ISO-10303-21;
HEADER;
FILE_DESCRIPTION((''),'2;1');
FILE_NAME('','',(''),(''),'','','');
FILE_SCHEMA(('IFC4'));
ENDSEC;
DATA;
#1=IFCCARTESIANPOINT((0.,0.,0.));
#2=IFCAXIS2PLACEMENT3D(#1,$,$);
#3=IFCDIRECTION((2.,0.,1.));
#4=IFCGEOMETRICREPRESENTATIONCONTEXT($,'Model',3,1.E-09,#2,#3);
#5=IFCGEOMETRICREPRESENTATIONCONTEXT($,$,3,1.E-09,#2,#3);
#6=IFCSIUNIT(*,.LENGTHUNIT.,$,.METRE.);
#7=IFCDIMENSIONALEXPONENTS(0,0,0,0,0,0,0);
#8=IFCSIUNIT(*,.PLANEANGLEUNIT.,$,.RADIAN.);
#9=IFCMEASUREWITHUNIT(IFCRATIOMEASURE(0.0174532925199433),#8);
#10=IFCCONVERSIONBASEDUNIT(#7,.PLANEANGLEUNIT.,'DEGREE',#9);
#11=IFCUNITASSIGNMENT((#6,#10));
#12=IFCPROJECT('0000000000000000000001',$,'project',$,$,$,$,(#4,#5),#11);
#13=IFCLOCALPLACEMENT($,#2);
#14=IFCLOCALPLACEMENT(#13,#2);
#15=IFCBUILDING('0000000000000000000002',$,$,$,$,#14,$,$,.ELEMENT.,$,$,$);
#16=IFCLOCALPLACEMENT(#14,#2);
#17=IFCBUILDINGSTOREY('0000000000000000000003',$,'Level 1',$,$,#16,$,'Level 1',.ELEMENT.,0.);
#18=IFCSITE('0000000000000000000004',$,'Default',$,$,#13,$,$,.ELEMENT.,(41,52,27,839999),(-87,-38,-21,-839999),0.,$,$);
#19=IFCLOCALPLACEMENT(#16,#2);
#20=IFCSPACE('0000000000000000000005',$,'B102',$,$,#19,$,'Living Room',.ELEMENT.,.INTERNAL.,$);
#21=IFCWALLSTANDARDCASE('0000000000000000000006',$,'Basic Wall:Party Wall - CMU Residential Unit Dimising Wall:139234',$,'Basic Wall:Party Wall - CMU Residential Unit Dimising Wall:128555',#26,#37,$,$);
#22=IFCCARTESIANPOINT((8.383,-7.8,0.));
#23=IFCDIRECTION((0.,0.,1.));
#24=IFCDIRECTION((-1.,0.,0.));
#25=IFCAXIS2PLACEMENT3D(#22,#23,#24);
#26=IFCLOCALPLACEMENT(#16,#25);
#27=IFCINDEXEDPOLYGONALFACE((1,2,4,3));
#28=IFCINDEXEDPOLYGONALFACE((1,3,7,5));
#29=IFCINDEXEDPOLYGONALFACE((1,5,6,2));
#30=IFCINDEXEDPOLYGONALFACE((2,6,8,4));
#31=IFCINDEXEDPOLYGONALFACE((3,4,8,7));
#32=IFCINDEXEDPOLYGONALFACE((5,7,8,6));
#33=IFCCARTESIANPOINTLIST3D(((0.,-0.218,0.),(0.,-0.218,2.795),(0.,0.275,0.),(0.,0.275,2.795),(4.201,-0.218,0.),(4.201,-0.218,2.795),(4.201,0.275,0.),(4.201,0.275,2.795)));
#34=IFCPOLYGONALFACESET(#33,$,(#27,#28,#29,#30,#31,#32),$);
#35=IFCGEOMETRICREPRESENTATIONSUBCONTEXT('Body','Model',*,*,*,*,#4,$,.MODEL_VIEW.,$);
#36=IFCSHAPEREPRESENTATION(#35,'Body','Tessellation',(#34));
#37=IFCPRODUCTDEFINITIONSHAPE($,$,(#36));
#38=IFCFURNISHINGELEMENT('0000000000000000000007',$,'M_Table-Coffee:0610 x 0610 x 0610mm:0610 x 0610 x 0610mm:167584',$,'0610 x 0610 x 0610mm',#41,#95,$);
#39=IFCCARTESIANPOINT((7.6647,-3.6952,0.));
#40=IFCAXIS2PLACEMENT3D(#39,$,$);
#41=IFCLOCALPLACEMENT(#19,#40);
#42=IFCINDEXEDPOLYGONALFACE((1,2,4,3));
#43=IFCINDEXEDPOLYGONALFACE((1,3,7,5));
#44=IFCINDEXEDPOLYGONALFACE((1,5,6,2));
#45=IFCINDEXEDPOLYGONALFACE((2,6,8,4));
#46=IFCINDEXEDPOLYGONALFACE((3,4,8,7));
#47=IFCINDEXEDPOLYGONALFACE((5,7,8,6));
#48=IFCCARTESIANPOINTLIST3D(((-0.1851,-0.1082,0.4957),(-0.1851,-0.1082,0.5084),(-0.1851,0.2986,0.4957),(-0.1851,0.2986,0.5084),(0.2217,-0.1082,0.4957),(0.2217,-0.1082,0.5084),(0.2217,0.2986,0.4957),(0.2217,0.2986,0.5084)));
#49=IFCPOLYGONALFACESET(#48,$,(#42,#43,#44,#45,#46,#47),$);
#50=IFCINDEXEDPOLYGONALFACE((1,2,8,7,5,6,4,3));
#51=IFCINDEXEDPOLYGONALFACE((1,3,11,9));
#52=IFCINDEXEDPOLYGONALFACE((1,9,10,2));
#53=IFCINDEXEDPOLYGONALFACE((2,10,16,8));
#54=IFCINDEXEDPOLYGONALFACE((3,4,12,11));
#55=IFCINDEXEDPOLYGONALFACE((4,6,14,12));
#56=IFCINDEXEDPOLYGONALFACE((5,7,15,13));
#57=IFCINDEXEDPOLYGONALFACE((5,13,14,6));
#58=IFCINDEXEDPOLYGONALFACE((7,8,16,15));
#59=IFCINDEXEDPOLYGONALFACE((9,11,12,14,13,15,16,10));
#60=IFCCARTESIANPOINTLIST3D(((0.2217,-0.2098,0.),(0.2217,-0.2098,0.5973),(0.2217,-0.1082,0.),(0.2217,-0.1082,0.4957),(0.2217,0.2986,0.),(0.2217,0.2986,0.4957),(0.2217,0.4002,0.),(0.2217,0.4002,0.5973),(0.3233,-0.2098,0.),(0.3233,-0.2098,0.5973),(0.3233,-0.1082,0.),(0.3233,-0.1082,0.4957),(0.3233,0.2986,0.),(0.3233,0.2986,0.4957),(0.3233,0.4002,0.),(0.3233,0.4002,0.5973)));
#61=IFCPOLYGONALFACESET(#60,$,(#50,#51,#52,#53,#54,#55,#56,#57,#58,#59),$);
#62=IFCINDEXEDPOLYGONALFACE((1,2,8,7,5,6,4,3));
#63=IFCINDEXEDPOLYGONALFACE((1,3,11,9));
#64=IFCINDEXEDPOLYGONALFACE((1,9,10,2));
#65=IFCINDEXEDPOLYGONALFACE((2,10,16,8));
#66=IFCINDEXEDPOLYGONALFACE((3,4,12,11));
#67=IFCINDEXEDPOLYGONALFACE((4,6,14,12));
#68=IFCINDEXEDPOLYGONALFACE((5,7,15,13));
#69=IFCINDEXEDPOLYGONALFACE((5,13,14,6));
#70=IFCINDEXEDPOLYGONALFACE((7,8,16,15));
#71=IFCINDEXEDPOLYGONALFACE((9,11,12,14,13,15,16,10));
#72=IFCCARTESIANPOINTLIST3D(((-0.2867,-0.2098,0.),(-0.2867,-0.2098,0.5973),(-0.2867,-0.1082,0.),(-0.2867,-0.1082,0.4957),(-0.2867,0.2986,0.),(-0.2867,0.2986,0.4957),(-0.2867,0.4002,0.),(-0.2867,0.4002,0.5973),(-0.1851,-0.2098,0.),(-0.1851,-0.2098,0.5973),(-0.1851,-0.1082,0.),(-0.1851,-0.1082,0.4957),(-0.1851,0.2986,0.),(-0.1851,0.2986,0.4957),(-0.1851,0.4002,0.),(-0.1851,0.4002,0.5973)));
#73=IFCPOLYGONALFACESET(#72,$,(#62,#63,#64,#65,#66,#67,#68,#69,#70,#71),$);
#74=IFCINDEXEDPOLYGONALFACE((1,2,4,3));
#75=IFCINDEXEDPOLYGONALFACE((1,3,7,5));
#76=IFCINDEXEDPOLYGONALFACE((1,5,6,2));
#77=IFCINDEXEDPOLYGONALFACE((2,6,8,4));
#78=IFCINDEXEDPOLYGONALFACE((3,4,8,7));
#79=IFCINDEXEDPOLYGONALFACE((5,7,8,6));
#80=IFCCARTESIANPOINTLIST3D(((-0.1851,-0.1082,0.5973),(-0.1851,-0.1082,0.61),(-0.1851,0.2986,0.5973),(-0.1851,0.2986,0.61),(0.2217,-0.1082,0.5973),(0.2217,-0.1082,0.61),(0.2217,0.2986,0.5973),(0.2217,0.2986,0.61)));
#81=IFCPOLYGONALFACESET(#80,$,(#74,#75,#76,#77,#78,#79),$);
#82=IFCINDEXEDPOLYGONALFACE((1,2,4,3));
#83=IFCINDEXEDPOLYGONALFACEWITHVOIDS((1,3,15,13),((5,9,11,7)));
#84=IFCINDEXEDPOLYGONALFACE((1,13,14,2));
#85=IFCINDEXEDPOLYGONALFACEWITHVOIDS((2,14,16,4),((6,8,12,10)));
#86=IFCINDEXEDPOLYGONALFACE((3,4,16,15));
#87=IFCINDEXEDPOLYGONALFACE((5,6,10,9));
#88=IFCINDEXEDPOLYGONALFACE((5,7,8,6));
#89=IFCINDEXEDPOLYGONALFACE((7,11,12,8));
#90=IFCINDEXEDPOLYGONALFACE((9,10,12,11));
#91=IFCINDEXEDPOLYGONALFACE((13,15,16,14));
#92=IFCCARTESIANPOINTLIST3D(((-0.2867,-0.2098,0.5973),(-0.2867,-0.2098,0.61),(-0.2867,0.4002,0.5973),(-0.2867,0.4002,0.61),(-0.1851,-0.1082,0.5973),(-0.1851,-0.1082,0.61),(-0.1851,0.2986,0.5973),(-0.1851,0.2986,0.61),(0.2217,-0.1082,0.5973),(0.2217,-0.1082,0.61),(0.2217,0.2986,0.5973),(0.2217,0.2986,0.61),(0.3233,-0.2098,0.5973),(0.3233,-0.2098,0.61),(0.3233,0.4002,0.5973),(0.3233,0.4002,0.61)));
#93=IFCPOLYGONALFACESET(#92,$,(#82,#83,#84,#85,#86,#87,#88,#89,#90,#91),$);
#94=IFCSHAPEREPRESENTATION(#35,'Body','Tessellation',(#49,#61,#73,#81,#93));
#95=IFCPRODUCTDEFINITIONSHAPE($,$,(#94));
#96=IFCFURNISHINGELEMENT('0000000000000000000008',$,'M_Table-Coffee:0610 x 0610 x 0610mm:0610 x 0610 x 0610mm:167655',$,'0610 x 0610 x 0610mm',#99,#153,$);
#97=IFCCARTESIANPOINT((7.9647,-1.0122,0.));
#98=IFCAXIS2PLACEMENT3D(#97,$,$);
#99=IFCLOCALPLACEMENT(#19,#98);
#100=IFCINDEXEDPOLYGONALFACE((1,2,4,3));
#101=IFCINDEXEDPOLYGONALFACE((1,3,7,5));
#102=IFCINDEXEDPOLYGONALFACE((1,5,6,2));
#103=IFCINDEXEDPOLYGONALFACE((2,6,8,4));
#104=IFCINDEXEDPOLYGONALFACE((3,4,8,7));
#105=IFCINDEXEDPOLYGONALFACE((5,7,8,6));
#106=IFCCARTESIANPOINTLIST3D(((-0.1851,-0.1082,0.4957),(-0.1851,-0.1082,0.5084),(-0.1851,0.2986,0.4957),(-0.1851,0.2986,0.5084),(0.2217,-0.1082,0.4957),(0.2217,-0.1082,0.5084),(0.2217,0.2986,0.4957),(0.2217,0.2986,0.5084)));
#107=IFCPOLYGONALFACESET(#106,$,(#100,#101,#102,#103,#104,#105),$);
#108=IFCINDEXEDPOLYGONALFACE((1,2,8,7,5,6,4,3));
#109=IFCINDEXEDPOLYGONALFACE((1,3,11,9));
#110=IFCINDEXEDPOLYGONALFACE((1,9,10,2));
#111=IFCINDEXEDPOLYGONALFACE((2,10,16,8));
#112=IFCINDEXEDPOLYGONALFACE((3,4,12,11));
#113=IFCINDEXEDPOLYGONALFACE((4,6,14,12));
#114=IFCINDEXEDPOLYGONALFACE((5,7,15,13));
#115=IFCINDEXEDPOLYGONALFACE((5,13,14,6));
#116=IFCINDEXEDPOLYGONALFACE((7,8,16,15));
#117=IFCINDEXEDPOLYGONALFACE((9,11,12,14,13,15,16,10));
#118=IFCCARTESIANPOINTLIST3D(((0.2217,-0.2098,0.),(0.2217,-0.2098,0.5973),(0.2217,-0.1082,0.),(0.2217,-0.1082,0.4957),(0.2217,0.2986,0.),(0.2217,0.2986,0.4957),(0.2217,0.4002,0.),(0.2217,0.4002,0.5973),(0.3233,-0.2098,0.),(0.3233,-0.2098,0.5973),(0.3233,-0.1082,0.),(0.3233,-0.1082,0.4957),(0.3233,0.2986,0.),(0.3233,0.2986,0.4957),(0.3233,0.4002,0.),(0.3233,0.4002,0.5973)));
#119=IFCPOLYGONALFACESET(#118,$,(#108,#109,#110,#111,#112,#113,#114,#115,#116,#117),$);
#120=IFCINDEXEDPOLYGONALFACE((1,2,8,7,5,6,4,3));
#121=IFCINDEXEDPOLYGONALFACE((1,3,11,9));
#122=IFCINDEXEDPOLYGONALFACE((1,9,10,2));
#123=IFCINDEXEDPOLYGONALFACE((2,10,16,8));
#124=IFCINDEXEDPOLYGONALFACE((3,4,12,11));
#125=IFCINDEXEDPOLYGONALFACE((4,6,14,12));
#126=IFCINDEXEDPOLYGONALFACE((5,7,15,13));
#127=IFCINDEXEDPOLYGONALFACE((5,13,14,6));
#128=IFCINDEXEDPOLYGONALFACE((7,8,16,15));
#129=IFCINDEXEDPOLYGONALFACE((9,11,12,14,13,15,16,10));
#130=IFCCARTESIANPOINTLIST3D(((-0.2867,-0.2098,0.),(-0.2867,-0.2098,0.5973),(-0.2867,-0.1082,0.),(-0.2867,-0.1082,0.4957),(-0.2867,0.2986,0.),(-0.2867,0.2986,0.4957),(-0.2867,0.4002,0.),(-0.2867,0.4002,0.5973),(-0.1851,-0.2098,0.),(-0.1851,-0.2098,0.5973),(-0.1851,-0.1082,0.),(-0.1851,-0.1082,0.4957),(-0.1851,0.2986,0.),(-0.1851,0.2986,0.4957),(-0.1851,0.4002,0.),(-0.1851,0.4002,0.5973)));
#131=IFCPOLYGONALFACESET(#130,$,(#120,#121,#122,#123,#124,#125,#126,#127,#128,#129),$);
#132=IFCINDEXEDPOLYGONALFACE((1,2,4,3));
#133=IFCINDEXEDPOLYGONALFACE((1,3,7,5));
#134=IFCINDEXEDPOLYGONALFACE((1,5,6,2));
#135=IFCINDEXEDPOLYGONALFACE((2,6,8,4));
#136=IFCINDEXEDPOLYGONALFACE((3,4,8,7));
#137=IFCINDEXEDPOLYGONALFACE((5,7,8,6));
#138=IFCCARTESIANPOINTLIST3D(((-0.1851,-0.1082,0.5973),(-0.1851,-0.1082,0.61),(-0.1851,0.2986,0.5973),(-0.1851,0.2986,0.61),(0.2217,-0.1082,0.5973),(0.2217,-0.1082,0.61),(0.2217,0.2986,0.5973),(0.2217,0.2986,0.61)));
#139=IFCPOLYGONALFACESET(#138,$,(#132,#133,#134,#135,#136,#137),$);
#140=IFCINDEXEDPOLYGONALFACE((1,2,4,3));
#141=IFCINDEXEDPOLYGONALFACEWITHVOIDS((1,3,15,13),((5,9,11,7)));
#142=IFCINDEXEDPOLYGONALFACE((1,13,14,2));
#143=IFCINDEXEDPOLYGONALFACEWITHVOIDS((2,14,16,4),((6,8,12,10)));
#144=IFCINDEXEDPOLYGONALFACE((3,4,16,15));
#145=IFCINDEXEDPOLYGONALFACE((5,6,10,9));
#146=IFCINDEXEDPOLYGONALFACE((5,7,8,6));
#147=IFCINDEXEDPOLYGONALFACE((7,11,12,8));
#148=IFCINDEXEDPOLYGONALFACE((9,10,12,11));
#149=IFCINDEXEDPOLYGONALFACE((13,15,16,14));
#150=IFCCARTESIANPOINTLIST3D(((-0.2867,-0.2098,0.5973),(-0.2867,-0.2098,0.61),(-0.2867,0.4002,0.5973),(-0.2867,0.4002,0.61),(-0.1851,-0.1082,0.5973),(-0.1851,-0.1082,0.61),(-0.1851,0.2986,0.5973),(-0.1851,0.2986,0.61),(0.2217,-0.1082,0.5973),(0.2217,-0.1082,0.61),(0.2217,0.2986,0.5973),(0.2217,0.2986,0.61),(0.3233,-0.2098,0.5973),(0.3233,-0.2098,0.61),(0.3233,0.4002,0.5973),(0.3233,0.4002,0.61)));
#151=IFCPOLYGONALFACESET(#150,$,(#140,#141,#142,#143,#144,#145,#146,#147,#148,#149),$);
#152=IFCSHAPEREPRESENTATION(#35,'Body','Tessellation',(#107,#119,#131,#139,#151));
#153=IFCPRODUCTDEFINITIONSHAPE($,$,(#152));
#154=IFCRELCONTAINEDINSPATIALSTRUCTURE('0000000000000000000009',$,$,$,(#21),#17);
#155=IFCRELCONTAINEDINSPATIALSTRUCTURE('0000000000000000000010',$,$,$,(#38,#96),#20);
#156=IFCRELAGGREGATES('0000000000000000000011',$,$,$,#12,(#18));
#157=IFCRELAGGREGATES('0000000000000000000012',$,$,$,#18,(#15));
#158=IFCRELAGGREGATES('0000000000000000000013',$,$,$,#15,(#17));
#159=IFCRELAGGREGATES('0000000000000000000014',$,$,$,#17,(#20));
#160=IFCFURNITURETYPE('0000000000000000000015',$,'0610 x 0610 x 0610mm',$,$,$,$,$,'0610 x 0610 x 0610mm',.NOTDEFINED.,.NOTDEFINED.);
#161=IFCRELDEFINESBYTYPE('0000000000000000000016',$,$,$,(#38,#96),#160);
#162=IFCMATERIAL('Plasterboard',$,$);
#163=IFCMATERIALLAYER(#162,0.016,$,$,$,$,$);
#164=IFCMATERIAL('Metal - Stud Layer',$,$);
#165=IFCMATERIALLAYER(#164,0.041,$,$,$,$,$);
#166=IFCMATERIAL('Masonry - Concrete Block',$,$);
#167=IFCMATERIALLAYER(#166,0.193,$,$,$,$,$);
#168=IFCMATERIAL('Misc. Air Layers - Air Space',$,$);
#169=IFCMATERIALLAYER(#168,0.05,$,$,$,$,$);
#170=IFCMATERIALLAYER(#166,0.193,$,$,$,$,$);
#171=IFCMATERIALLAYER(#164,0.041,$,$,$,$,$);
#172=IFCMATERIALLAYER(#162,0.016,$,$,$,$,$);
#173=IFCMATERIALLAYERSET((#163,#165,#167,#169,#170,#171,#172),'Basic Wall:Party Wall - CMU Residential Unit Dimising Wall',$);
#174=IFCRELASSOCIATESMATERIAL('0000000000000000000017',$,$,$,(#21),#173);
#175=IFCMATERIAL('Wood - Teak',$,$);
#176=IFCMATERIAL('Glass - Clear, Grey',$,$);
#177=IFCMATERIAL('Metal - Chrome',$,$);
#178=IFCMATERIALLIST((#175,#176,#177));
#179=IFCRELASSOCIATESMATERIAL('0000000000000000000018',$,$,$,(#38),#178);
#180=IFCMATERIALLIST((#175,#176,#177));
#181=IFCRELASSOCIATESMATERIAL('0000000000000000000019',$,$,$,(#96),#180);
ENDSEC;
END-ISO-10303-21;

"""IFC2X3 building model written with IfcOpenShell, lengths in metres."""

from ifc_helpers import new_model, entity, si_unit, converted_unit, direction, frame, frame_2d, origin, origin_2d_with_axis, place, context, subcontext, project, spatial, polyline, rectangle, outline, extrude, clip, bounded_halfspace, source, transform, mapped, material, material_list, layer, layer_set, layer_usage, type_object, type_shapes, element, save


model = new_model("IFC2X3")

# Units and contexts
model_context = context("Model", 3, precision=1e-09, world=origin(), true_north=direction((2.0, 0.0, 1.0)))
context_of_model = context(None, 3, precision=1e-09, world=origin(), true_north=direction((2.0, 0.0, 1.0)))
body_context = subcontext(model_context, "Body", "Model", "MODEL_VIEW")
ifc_project = project(units=[si_unit("LENGTHUNIT", "METRE"), converted_unit("PLANEANGLEUNIT", "DEGREE", entity("IfcRatioMeasure", 0.0174532925199433), si_unit("PLANEANGLEUNIT", "RADIAN"), dimensions=[0, 0, 0, 0, 0, 0, 0])], contexts=[model_context, context_of_model])

# Site, building, storey
site_placement = place(None, origin())
site = spatial("IfcSite", under=ifc_project, at=site_placement, Name="Default", CompositionType="ELEMENT", RefLatitude=(41, 52, 27, 839999), RefLongitude=(-87, -38, -21, -839999), RefElevation=0.0)
building_placement = place(site_placement, origin())
building = spatial("IfcBuilding", under=site, at=building_placement, CompositionType="ELEMENT")
storey_placement = place(building_placement, origin())
storey = spatial("IfcBuildingStorey", under=building, at=storey_placement, Name="Level 1", LongName="Level 1", CompositionType="ELEMENT", Elevation=0.0)

# Shared definitions
ifc_material_1 = material(Name="Misc. Air Layers - Air Space")
ifc_material_2 = material(Name="Masonry - Concrete Block")
ifc_material_3 = material(Name="Metal - Stud Layer")
ifc_material_4 = material(Name="Plasterboard")

# Wall
ifc_layer_1 = layer(ifc_material_4, 0.016)
ifc_layer_2 = layer(ifc_material_3, 0.041)
ifc_layer_3 = layer(ifc_material_2, 0.193)
ifc_layer_4 = layer(ifc_material_1, 0.05)
ifc_layer_5 = layer(ifc_material_2, 0.193)
ifc_layer_6 = layer(ifc_material_3, 0.041)
ifc_layer_7 = layer(ifc_material_4, 0.016)
ifc_layer_set_1 = layer_set([ifc_layer_1, ifc_layer_2, ifc_layer_3, ifc_layer_4, ifc_layer_5, ifc_layer_6, ifc_layer_7], Name="Basic Wall:Party Wall - CMU Residential Unit Dimising Wall")
ifc_layer_usage_1 = layer_usage(ifc_layer_set_1, "AXIS2", "NEGATIVE", 0.275)
wall_1_placement = place(storey_placement, frame((8.383, -7.8, 0.0), z_axis=(0.0, 0.0, 1.0), x_axis=(-1.0, 0.0, 0.0)))
element("IfcWallStandardCase", 1, at=wall_1_placement, inside=storey, material=ifc_layer_usage_1, Name="Basic Wall:Party Wall - CMU Residential Unit Dimising Wall:139234", ObjectType="Basic Wall:Party Wall - CMU Residential Unit Dimising Wall:128555", context=body_context, shape_type="Clipping", body=[
    clip(clip(extrude(rectangle(XDim=4.201, YDim=0.55, at=frame_2d((2.1005, 0.0), x_axis=(-1.0, 0.0))), origin(), (0.0, 0.0, 1.0), 2.795), bounded_halfspace(frame((0.0, -0.218, 2.795), z_axis=(0.0, 1.0, 0.0), x_axis=(-1.0, 0.0, 0.0)), True, frame((0.0, -0.218, 2.795), z_axis=(0.0, 1.0, 0.0), x_axis=(-1.0, 0.0, 0.0)), polyline([(0.0, 0.0), (-3.708, 0.0), (-4.201, 0.0), (-4.201, -2.795), (0.0, -2.795), (0.0, 0.0)]))), bounded_halfspace(frame((4.201, 0.275, 0.0), z_axis=(-1.0, 0.0, 0.0), x_axis=(0.0, -1.0, 0.0)), True, frame((4.201, 0.275, 0.0), z_axis=(-1.0, 0.0, 0.0), x_axis=(0.0, -1.0, 0.0)), polyline([(0.0, 0.0), (0.493, 0.0), (0.493, 2.795), (0.0, 2.795), (0.0, 0.0)]))),
])

# Shared definitions
space_1_placement = place(storey_placement, origin())
space_1 = spatial("IfcSpace", under=storey, at=space_1_placement, Name="B102", LongName="Living Room", CompositionType="ELEMENT", InteriorOrExteriorSpace="INTERNAL")

# Furnishing elements
ifc_material_5 = material(Name="Wood - Teak")
ifc_material_6 = material(Name="Glass - Clear, Grey")
ifc_material_7 = material(Name="Metal - Chrome")
ifc_material_list_1 = material_list([ifc_material_5, ifc_material_6, ifc_material_7])
furniture_type_1 = type_object("IfcFurnitureType", Name="0610 x 0610 x 0610mm", ElementType="0610 x 0610 x 0610mm", AssemblyPlace="NOTDEFINED")
shared_shape_1 = source(origin(), body_context, "Body", "SweptSolid", [
    extrude(rectangle(XDim=0.4068, YDim=0.4068, at=origin_2d_with_axis()), frame((0.0183, 0.0952, 0.4957), z_axis=(0.0, 0.0, 1.0), x_axis=(-1.0, 0.0, 0.0)), (0.0, 0.0, 1.0), 0.0127),
    extrude(outline(polyline([(-0.2732, -0.305), (0.324, -0.305), (0.324, 0.305), (-0.2732, 0.305), (-0.2732, 0.2034), (0.2225, 0.2034), (0.2225, -0.2034), (-0.2732, -0.2034), (-0.2732, -0.305)])), frame((0.2217, 0.0952, 0.2732), z_axis=(1.0, 0.0, 0.0), x_axis=(0.0, 0.0, 1.0)), (0.0, 0.0, 1.0), 0.1016),
    extrude(outline(polyline([(-0.305, -0.3241), (0.305, -0.3241), (0.305, 0.2733), (0.2034, 0.2733), (0.2034, -0.2224), (-0.2034, -0.2224), (-0.2034, 0.2733), (-0.305, 0.2733), (-0.305, -0.3241)])), frame((-0.2867, 0.0952, 0.2733), z_axis=(1.0, 0.0, 0.0), x_axis=(0.0, -1.0, 0.0)), (0.0, 0.0, 1.0), 0.1016),
    extrude(rectangle(XDim=0.4068, YDim=0.4068, at=origin_2d_with_axis()), frame((0.0183, 0.0952, 0.5973), z_axis=(0.0, 0.0, 1.0), x_axis=(-1.0, 0.0, 0.0)), (0.0, 0.0, 1.0), 0.0127),
    extrude(outline(polyline([(-0.305, -0.305), (0.305, -0.305), (0.305, 0.305), (-0.305, 0.305), (-0.305, -0.305)]), holes=[polyline([(-0.2034, -0.2034), (-0.2034, 0.2034), (0.2034, 0.2034), (0.2034, -0.2034), (-0.2034, -0.2034)])]), frame((0.0183, 0.0952, 0.5973), z_axis=(0.0, 0.0, 1.0), x_axis=(-1.0, 0.0, 0.0)), (0.0, 0.0, 1.0), 0.0127),
])
type_shapes(furniture_type_1, [shared_shape_1])
furnishing_1_placement = place(space_1_placement, frame((7.6647, -3.6952, 0.0)))
element("IfcFurnishingElement", 2, at=furnishing_1_placement, inside=space_1, type_object=furniture_type_1, material=ifc_material_list_1, Name="M_Table-Coffee:0610 x 0610 x 0610mm:0610 x 0610 x 0610mm:167584", ObjectType="0610 x 0610 x 0610mm", context=body_context, shape_type="MappedRepresentation", body=[
    mapped(shared_shape_1, transform((0.0, 0.0, 0.0), scale=1.0)),
])
ifc_material_list_2 = material_list([ifc_material_5, ifc_material_6, ifc_material_7])
furnishing_2_placement = place(space_1_placement, frame((7.9647, -1.0122, 0.0)))
element("IfcFurnishingElement", 3, at=furnishing_2_placement, inside=space_1, type_object=furniture_type_1, material=ifc_material_list_2, Name="M_Table-Coffee:0610 x 0610 x 0610mm:0610 x 0610 x 0610mm:167655", ObjectType="0610 x 0610 x 0610mm", context=body_context, shape_type="MappedRepresentation", body=[
    mapped(shared_shape_1, transform((0.0, 0.0, 0.0), scale=1.0)),
])

save(model, "model.ifc")
